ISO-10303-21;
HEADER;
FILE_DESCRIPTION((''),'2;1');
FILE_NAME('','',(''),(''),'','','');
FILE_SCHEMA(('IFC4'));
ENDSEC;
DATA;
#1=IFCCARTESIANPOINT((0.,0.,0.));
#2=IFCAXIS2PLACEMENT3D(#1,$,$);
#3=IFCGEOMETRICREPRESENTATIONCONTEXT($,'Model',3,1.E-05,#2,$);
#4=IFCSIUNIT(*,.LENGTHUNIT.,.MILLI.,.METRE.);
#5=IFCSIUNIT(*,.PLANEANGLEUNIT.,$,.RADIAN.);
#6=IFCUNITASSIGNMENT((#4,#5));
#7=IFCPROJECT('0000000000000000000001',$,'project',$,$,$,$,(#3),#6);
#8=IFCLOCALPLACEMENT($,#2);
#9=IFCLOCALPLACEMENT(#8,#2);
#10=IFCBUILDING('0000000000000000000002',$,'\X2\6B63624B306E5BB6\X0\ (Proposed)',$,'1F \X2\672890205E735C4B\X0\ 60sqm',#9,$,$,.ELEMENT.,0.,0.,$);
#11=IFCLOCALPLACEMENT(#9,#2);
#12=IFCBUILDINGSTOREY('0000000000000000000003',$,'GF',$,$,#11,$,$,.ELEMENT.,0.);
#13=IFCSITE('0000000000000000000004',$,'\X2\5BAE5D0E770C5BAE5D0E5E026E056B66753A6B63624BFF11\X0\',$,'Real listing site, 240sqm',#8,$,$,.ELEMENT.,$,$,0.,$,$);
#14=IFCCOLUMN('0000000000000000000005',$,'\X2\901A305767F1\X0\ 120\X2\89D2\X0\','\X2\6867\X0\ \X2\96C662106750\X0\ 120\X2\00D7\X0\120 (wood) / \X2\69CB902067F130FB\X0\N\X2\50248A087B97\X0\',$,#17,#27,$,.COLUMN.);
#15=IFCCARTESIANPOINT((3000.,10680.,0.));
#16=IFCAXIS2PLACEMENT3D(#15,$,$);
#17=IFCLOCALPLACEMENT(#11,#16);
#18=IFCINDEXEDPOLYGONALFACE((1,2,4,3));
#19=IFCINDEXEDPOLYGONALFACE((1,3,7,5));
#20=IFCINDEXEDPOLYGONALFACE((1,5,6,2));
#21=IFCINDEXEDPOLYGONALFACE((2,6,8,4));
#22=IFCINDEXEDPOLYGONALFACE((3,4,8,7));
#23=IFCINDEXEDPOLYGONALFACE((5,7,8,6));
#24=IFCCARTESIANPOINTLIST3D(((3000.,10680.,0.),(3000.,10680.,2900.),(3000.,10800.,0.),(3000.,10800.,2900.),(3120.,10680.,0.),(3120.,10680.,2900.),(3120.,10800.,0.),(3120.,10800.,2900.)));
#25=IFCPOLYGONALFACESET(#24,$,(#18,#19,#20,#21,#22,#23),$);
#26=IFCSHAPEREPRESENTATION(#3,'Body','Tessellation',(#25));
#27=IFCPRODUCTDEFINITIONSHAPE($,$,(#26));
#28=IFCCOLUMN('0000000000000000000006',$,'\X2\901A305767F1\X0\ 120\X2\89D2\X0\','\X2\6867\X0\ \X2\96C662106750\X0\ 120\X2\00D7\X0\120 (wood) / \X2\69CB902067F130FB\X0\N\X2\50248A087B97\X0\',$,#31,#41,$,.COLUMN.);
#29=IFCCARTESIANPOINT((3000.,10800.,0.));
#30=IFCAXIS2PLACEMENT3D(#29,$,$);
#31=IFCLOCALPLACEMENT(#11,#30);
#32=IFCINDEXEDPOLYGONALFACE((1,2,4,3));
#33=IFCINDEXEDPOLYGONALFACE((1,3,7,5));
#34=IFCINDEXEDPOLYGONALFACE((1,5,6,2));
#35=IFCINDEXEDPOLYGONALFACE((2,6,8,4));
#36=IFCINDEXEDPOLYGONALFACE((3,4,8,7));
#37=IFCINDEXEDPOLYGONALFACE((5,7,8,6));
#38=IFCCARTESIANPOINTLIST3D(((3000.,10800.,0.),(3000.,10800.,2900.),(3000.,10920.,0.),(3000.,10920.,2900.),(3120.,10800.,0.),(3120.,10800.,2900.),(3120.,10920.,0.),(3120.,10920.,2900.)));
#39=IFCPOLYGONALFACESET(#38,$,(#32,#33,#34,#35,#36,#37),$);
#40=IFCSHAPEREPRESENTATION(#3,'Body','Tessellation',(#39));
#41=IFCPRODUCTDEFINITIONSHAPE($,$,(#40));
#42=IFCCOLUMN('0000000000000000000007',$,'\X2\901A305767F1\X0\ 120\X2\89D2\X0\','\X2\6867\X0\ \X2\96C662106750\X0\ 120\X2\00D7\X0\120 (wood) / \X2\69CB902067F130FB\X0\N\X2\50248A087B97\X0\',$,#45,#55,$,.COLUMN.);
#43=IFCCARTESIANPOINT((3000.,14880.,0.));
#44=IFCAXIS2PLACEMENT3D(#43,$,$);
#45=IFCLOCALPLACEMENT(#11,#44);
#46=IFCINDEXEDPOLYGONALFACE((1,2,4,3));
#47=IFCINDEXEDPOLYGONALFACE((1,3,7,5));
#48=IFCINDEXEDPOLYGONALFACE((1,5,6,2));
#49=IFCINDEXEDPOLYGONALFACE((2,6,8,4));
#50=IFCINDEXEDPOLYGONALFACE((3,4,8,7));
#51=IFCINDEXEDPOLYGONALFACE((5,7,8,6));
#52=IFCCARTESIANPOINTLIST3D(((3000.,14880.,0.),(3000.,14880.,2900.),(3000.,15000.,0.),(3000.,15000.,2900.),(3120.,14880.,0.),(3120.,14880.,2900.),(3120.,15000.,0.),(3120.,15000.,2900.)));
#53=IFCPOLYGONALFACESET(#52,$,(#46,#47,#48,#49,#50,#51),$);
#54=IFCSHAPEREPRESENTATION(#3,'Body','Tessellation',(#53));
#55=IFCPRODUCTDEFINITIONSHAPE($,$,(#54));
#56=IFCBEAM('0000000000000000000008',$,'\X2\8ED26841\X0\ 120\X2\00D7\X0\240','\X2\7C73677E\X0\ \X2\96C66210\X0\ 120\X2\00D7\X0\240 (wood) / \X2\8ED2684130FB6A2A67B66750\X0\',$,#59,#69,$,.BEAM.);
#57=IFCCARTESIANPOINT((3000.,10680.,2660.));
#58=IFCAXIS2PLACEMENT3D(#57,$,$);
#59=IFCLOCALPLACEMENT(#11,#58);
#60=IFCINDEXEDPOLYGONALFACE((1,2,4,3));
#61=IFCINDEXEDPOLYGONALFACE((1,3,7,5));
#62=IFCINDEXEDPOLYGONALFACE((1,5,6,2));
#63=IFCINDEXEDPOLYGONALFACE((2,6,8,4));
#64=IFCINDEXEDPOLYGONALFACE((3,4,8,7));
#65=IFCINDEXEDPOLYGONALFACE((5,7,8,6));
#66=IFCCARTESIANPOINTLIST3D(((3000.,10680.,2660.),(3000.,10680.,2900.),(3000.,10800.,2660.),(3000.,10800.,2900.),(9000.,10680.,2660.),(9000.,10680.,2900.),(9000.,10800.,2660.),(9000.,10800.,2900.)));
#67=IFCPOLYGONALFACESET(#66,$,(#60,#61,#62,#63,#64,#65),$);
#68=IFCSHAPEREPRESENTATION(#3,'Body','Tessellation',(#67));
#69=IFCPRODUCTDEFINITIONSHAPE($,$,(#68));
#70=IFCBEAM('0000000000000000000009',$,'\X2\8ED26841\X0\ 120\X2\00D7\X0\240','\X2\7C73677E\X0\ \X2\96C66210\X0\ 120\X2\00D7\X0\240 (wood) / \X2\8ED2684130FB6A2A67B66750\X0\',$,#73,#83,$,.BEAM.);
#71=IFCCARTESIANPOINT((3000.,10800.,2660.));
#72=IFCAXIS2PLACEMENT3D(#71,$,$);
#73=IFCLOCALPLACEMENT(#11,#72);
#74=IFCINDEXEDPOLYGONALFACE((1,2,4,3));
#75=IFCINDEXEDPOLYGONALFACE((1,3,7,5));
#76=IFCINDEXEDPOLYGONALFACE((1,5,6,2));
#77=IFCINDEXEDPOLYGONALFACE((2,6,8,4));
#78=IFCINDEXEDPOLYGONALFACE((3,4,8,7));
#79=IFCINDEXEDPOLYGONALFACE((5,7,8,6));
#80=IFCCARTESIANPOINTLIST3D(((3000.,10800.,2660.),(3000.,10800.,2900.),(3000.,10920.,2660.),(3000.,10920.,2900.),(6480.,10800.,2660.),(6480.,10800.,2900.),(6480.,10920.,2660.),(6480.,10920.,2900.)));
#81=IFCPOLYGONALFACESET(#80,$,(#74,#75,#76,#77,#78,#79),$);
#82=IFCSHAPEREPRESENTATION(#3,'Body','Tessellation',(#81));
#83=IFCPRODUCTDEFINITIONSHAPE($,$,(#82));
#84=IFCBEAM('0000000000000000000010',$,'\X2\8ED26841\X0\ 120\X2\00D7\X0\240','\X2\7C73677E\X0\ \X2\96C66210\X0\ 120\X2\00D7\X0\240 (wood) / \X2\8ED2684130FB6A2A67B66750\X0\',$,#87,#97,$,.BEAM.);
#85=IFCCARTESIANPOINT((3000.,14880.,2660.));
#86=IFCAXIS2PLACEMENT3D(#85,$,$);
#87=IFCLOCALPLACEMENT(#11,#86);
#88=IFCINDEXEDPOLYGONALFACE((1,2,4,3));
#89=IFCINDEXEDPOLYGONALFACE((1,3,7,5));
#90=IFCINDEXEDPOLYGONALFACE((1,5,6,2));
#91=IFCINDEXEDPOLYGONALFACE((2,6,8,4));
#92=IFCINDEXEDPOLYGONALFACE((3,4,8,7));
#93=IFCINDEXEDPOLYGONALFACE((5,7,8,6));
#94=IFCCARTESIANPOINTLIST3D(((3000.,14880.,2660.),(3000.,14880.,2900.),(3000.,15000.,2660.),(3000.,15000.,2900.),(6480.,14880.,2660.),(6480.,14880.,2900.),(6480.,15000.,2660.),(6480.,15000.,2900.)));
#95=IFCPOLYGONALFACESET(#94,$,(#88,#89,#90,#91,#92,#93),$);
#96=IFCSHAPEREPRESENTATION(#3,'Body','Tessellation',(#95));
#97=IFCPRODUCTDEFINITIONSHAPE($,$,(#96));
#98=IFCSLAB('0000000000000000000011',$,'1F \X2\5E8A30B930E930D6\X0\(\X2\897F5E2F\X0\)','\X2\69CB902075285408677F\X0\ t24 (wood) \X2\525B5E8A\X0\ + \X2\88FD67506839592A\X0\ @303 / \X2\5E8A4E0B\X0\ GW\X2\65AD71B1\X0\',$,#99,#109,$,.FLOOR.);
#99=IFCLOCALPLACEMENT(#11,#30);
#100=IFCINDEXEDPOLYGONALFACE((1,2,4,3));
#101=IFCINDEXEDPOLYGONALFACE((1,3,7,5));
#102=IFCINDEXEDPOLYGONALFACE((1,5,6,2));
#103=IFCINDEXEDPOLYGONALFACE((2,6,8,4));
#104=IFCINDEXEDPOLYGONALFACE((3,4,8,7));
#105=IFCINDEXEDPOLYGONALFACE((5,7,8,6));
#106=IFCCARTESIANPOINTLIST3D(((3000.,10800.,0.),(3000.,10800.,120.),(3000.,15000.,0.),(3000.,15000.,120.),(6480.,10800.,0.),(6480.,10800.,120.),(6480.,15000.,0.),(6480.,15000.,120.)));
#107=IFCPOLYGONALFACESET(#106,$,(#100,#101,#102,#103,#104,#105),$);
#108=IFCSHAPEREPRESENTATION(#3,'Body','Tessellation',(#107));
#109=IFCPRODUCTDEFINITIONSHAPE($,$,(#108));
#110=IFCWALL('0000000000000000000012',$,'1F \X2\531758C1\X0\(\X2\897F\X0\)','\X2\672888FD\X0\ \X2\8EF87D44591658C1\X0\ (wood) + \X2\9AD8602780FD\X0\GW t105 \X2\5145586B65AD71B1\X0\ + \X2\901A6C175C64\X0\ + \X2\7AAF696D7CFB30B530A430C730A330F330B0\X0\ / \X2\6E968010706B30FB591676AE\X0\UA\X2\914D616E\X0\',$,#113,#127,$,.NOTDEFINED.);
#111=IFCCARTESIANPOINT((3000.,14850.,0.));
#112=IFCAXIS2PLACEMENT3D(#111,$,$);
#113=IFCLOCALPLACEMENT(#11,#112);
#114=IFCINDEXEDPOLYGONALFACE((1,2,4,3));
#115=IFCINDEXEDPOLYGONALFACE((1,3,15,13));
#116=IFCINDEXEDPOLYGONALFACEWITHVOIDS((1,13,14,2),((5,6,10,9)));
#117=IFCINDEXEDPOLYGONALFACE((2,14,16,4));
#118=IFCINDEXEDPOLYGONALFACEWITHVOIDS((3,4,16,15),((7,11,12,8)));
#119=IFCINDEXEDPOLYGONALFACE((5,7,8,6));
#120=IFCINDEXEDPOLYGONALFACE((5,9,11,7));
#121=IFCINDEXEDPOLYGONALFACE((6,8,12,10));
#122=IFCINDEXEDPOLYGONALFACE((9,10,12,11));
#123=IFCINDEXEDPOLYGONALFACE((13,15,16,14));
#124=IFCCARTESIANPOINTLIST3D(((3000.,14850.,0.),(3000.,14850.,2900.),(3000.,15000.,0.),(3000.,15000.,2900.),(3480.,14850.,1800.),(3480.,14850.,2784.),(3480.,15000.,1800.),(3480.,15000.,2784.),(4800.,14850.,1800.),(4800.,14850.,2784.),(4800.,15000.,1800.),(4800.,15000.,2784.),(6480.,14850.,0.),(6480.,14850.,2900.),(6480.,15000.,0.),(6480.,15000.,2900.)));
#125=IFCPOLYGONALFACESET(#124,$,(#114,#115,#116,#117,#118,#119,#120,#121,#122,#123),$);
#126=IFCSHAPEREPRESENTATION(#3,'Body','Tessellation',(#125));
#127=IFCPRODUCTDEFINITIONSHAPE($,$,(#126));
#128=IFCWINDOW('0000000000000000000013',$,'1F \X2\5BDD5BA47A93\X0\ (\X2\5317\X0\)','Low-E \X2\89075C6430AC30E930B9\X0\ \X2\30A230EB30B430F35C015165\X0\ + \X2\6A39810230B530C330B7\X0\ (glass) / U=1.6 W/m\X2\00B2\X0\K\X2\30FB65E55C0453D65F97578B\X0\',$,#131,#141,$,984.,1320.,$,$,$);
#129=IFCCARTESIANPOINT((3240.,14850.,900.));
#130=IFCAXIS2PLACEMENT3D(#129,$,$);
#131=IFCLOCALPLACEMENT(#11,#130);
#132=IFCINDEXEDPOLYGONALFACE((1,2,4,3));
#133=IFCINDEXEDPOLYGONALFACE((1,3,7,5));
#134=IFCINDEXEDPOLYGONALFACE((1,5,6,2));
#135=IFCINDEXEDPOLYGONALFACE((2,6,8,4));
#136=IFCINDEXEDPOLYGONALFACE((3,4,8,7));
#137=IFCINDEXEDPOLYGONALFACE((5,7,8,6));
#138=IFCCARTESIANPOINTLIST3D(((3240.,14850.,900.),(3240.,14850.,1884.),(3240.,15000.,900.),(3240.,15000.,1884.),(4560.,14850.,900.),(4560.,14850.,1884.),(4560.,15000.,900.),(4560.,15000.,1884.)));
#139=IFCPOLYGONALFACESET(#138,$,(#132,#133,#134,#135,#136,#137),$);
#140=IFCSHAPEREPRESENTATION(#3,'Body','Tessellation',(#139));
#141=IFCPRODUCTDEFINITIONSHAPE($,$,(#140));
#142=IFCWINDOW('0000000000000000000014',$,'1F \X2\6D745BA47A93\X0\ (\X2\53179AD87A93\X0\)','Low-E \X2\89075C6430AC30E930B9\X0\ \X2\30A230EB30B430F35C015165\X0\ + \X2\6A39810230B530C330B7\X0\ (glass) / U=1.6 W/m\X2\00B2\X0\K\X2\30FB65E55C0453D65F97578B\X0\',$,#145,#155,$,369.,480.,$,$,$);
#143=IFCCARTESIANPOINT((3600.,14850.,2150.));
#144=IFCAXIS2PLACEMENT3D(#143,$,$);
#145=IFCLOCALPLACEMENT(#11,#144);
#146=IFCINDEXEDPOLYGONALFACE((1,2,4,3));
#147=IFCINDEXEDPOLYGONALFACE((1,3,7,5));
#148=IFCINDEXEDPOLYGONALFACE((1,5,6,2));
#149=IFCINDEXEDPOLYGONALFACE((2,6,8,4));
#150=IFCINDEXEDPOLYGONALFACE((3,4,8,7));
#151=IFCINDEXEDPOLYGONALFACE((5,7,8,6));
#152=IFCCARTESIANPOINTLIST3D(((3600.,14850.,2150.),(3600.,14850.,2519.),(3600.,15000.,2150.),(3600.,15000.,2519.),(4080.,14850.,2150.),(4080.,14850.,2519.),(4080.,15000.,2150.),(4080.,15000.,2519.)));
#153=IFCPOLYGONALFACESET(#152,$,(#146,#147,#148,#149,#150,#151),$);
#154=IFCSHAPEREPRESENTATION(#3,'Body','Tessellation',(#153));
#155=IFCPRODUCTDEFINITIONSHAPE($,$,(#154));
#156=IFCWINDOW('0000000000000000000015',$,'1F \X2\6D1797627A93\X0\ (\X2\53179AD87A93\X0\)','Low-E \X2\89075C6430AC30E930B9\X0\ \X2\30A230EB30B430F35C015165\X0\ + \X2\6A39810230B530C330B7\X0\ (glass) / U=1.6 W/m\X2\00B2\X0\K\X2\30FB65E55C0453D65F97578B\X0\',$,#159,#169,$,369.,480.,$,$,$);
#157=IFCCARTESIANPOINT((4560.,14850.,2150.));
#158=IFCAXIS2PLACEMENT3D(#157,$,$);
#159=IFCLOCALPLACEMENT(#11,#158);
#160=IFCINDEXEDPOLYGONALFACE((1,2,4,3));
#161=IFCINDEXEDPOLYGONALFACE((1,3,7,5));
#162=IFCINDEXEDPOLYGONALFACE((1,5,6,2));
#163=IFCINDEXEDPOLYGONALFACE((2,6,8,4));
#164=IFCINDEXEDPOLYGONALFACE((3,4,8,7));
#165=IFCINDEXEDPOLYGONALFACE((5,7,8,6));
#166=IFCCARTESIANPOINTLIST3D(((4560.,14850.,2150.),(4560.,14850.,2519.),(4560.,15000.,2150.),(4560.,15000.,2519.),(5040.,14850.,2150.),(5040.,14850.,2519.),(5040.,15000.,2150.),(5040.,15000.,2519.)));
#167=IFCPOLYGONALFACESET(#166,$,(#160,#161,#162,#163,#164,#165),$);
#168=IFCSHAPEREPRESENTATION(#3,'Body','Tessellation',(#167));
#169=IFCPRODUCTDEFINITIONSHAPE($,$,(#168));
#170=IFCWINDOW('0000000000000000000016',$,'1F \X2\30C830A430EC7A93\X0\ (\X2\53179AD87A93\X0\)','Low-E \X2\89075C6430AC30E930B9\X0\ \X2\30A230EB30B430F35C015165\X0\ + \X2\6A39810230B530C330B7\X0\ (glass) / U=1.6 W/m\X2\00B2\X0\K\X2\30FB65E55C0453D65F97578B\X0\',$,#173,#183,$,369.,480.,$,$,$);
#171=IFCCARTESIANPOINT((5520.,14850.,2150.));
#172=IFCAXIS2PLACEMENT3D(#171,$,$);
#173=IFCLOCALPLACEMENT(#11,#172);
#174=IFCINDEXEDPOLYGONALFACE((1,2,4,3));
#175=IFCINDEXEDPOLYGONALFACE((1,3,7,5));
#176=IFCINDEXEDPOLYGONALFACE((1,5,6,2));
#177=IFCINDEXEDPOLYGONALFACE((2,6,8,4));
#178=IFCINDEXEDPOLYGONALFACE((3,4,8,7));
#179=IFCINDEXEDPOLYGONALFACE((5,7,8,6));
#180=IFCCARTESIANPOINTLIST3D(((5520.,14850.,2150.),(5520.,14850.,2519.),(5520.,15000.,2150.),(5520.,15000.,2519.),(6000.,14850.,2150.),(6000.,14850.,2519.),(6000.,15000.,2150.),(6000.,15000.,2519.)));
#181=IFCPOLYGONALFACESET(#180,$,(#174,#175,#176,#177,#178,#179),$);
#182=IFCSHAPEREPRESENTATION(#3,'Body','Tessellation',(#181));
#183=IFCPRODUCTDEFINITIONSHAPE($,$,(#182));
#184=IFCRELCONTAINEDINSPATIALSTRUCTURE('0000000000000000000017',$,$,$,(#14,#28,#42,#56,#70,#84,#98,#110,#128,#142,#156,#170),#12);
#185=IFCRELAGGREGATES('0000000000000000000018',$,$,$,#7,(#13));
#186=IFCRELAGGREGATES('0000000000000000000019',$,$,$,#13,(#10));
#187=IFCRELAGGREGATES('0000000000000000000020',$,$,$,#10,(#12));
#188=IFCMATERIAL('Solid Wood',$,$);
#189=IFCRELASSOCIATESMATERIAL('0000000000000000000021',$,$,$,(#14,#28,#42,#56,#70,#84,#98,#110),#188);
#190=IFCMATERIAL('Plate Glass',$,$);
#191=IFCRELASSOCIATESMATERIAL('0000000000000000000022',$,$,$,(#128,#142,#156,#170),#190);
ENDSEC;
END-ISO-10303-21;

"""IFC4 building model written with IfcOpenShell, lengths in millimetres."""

from ifc_helpers import new_model, si_unit, frame, frame_2d, origin, place, context, project, spatial, rectangle, extrude, material, element, fill, save


model = new_model("IFC4")

# Units and contexts
model_context = context("Model", 3, precision=1e-05, world=origin())
ifc_project = project(units=[si_unit("LENGTHUNIT", "METRE", prefix="MILLI"), si_unit("PLANEANGLEUNIT", "RADIAN")], contexts=[model_context])

# Site, building, storey
site_placement = place(None, origin())
site = spatial("IfcSite", under=ifc_project, at=site_placement, Name="宮崎県宮崎市清武町正手１", ObjectType="Real listing site, 240sqm", CompositionType="ELEMENT", RefElevation=0.0)
building_placement = place(site_placement, origin())
building = spatial("IfcBuilding", under=site, at=building_placement, Name="正手の家 (Proposed)", ObjectType="1F 木造平屋 60sqm", CompositionType="ELEMENT", ElevationOfRefHeight=0.0, ElevationOfTerrain=0.0)
storey_placement = place(building_placement, origin())
storey = spatial("IfcBuildingStorey", under=building, at=storey_placement, Name="GF", CompositionType="ELEMENT", Elevation=0.0)

# Columns
ifc_material_1 = material(Name="Solid Wood")
column_1_placement = place(storey_placement, frame((3000.0, 10680.0, 0.0)))
element("IfcColumn", 1, at=column_1_placement, inside=storey, material=ifc_material_1, Name="通し柱 120角", Description="桧 集成材 120×120 (wood) / 構造柱・N値計算", PredefinedType="COLUMN", context=model_context, shape_type="SweptSolid", body=[
    extrude(rectangle(XDim=120.0, YDim=120.0, at=frame_2d((60.0, 60.0))), frame((3000.0, 10680.0, 0.0)), (0.0, 0.0, 1.0), 2900.0),
])
column_2_placement = place(storey_placement, frame((3000.0, 10800.0, 0.0)))
element("IfcColumn", 2, at=column_2_placement, inside=storey, material=ifc_material_1, Name="通し柱 120角", Description="桧 集成材 120×120 (wood) / 構造柱・N値計算", PredefinedType="COLUMN", context=model_context, shape_type="SweptSolid", body=[
    extrude(rectangle(XDim=120.0, YDim=120.0, at=frame_2d((60.0, 60.0))), frame((3000.0, 10800.0, 0.0)), (0.0, 0.0, 1.0), 2900.0),
])
column_3_placement = place(storey_placement, frame((3000.0, 14880.0, 0.0)))
element("IfcColumn", 3, at=column_3_placement, inside=storey, material=ifc_material_1, Name="通し柱 120角", Description="桧 集成材 120×120 (wood) / 構造柱・N値計算", PredefinedType="COLUMN", context=model_context, shape_type="SweptSolid", body=[
    extrude(rectangle(XDim=120.0, YDim=120.0, at=frame_2d((60.0, 60.0))), frame((3000.0, 14880.0, 0.0)), (0.0, 0.0, 1.0), 2900.0),
])

# Beams
beam_1_placement = place(storey_placement, frame((3000.0, 10680.0, 2660.0)))
element("IfcBeam", 4, at=beam_1_placement, inside=storey, material=ifc_material_1, Name="軒桁 120×240", Description="米松 集成 120×240 (wood) / 軒桁・横架材", PredefinedType="BEAM", context=model_context, shape_type="SweptSolid", body=[
    extrude(rectangle(XDim=6000.0, YDim=120.0, at=frame_2d((3000.0, 60.0))), frame((3000.0, 10680.0, 2660.0)), (0.0, 0.0, 1.0), 240.0),
])
beam_2_placement = place(storey_placement, frame((3000.0, 10800.0, 2660.0)))
element("IfcBeam", 5, at=beam_2_placement, inside=storey, material=ifc_material_1, Name="軒桁 120×240", Description="米松 集成 120×240 (wood) / 軒桁・横架材", PredefinedType="BEAM", context=model_context, shape_type="SweptSolid", body=[
    extrude(rectangle(XDim=3480.0, YDim=120.0, at=frame_2d((1740.0, 60.0))), frame((3000.0, 10800.0, 2660.0)), (0.0, 0.0, 1.0), 240.0),
])
beam_3_placement = place(storey_placement, frame((3000.0, 14880.0, 2660.0)))
element("IfcBeam", 6, at=beam_3_placement, inside=storey, material=ifc_material_1, Name="軒桁 120×240", Description="米松 集成 120×240 (wood) / 軒桁・横架材", PredefinedType="BEAM", context=model_context, shape_type="SweptSolid", body=[
    extrude(rectangle(XDim=3480.0, YDim=120.0, at=frame_2d((1740.0, 60.0))), frame((3000.0, 14880.0, 2660.0)), (0.0, 0.0, 1.0), 240.0),
])

# Slab
slab_placement = place(storey_placement, frame((3000.0, 10800.0, 0.0)))
element("IfcSlab", 7, at=slab_placement, inside=storey, material=ifc_material_1, Name="1F 床スラブ(西帯)", Description="構造用合板 t24 (wood) 剛床 + 製材根太 @303 / 床下 GW断熱", PredefinedType="FLOOR", context=model_context, shape_type="SweptSolid", body=[
    extrude(rectangle(XDim=3480.0, YDim=4200.0, at=frame_2d((1740.0, 2100.0))), frame((3000.0, 10800.0, 0.0)), (0.0, 0.0, 1.0), 120.0),
])

# Wall, openings, windows
wall_1_placement = place(storey_placement, frame((3000.0, 14850.0, 0.0)))
wall_1 = element("IfcWall", 8, at=wall_1_placement, inside=storey, material=ifc_material_1, Name="1F 北壁(西)", Description="木製 軸組外壁 (wood) + 高性能GW t105 充填断熱 + 通気層 + 窯業系サイディング / 準耐火・外皮UA配慮", PredefinedType="NOTDEFINED", context=model_context, shape_type="SweptSolid", body=[
    extrude(rectangle(XDim=3480.0, YDim=150.0, at=frame_2d((1740.0, 75.0))), frame((3000.0, 14850.0, 0.0)), (0.0, 0.0, 1.0), 2900.0),
])
opening_1_placement = place(storey_placement, frame((3240.0, 14850.0, 900.0)))
opening_1 = element("IfcOpeningElement", 9, at=opening_1_placement, cuts=wall_1, PredefinedType="NOTDEFINED", context=model_context, shape_type="SweptSolid", body=[
    extrude(rectangle(XDim=1320.0, YDim=150.0, at=frame_2d((660.0, 75.0))), frame((3240.0, 14850.0, 900.0)), (0.0, 0.0, 1.0), 984.0),
])
opening_2_placement = place(storey_placement, frame((3600.0, 14850.0, 2150.0)))
opening_2 = element("IfcOpeningElement", 10, at=opening_2_placement, cuts=wall_1, PredefinedType="NOTDEFINED", context=model_context, shape_type="SweptSolid", body=[
    extrude(rectangle(XDim=480.0, YDim=150.0, at=frame_2d((240.0, 75.0))), frame((3600.0, 14850.0, 2150.0)), (0.0, 0.0, 1.0), 369.0),
])
opening_3_placement = place(storey_placement, frame((4560.0, 14850.0, 2150.0)))
opening_3 = element("IfcOpeningElement", 11, at=opening_3_placement, cuts=wall_1, PredefinedType="NOTDEFINED", context=model_context, shape_type="SweptSolid", body=[
    extrude(rectangle(XDim=480.0, YDim=150.0, at=frame_2d((240.0, 75.0))), frame((4560.0, 14850.0, 2150.0)), (0.0, 0.0, 1.0), 369.0),
])
opening_4_placement = place(storey_placement, frame((5520.0, 14850.0, 2150.0)))
opening_4 = element("IfcOpeningElement", 12, at=opening_4_placement, cuts=wall_1, PredefinedType="NOTDEFINED", context=model_context, shape_type="SweptSolid", body=[
    extrude(rectangle(XDim=480.0, YDim=150.0, at=frame_2d((240.0, 75.0))), frame((5520.0, 14850.0, 2150.0)), (0.0, 0.0, 1.0), 369.0),
])
ifc_material_2 = material(Name="Plate Glass")
window_1_placement = place(storey_placement, frame((3240.0, 14850.0, 900.0)))
window_1 = element("IfcWindow", 13, at=window_1_placement, inside=storey, material=ifc_material_2, Name="1F 寝室窓 (北)", Description="Low-E 複層ガラス アルゴン封入 + 樹脂サッシ (glass) / U=1.6 W/m²K・日射取得型", OverallHeight=984.0, OverallWidth=1320.0, context=model_context, shape_type="SweptSolid", body=[
    extrude(rectangle(XDim=1320.0, YDim=150.0, at=frame_2d((660.0, 75.0))), frame((3240.0, 14850.0, 900.0)), (0.0, 0.0, 1.0), 984.0),
])
fill(opening_1, window_1)
window_2_placement = place(storey_placement, frame((3600.0, 14850.0, 2150.0)))
window_2 = element("IfcWindow", 14, at=window_2_placement, inside=storey, material=ifc_material_2, Name="1F 浴室窓 (北高窓)", Description="Low-E 複層ガラス アルゴン封入 + 樹脂サッシ (glass) / U=1.6 W/m²K・日射取得型", OverallHeight=369.0, OverallWidth=480.0, context=model_context, shape_type="SweptSolid", body=[
    extrude(rectangle(XDim=480.0, YDim=150.0, at=frame_2d((240.0, 75.0))), frame((3600.0, 14850.0, 2150.0)), (0.0, 0.0, 1.0), 369.0),
])
fill(opening_2, window_2)
window_3_placement = place(storey_placement, frame((4560.0, 14850.0, 2150.0)))
window_3 = element("IfcWindow", 15, at=window_3_placement, inside=storey, material=ifc_material_2, Name="1F 洗面窓 (北高窓)", Description="Low-E 複層ガラス アルゴン封入 + 樹脂サッシ (glass) / U=1.6 W/m²K・日射取得型", OverallHeight=369.0, OverallWidth=480.0, context=model_context, shape_type="SweptSolid", body=[
    extrude(rectangle(XDim=480.0, YDim=150.0, at=frame_2d((240.0, 75.0))), frame((4560.0, 14850.0, 2150.0)), (0.0, 0.0, 1.0), 369.0),
])
fill(opening_3, window_3)
window_4_placement = place(storey_placement, frame((5520.0, 14850.0, 2150.0)))
window_4 = element("IfcWindow", 16, at=window_4_placement, inside=storey, material=ifc_material_2, Name="1F トイレ窓 (北高窓)", Description="Low-E 複層ガラス アルゴン封入 + 樹脂サッシ (glass) / U=1.6 W/m²K・日射取得型", OverallHeight=369.0, OverallWidth=480.0, context=model_context, shape_type="SweptSolid", body=[
    extrude(rectangle(XDim=480.0, YDim=150.0, at=frame_2d((240.0, 75.0))), frame((5520.0, 14850.0, 2150.0)), (0.0, 0.0, 1.0), 369.0),
])
fill(opening_4, window_4)

save(model, "model.ifc")
